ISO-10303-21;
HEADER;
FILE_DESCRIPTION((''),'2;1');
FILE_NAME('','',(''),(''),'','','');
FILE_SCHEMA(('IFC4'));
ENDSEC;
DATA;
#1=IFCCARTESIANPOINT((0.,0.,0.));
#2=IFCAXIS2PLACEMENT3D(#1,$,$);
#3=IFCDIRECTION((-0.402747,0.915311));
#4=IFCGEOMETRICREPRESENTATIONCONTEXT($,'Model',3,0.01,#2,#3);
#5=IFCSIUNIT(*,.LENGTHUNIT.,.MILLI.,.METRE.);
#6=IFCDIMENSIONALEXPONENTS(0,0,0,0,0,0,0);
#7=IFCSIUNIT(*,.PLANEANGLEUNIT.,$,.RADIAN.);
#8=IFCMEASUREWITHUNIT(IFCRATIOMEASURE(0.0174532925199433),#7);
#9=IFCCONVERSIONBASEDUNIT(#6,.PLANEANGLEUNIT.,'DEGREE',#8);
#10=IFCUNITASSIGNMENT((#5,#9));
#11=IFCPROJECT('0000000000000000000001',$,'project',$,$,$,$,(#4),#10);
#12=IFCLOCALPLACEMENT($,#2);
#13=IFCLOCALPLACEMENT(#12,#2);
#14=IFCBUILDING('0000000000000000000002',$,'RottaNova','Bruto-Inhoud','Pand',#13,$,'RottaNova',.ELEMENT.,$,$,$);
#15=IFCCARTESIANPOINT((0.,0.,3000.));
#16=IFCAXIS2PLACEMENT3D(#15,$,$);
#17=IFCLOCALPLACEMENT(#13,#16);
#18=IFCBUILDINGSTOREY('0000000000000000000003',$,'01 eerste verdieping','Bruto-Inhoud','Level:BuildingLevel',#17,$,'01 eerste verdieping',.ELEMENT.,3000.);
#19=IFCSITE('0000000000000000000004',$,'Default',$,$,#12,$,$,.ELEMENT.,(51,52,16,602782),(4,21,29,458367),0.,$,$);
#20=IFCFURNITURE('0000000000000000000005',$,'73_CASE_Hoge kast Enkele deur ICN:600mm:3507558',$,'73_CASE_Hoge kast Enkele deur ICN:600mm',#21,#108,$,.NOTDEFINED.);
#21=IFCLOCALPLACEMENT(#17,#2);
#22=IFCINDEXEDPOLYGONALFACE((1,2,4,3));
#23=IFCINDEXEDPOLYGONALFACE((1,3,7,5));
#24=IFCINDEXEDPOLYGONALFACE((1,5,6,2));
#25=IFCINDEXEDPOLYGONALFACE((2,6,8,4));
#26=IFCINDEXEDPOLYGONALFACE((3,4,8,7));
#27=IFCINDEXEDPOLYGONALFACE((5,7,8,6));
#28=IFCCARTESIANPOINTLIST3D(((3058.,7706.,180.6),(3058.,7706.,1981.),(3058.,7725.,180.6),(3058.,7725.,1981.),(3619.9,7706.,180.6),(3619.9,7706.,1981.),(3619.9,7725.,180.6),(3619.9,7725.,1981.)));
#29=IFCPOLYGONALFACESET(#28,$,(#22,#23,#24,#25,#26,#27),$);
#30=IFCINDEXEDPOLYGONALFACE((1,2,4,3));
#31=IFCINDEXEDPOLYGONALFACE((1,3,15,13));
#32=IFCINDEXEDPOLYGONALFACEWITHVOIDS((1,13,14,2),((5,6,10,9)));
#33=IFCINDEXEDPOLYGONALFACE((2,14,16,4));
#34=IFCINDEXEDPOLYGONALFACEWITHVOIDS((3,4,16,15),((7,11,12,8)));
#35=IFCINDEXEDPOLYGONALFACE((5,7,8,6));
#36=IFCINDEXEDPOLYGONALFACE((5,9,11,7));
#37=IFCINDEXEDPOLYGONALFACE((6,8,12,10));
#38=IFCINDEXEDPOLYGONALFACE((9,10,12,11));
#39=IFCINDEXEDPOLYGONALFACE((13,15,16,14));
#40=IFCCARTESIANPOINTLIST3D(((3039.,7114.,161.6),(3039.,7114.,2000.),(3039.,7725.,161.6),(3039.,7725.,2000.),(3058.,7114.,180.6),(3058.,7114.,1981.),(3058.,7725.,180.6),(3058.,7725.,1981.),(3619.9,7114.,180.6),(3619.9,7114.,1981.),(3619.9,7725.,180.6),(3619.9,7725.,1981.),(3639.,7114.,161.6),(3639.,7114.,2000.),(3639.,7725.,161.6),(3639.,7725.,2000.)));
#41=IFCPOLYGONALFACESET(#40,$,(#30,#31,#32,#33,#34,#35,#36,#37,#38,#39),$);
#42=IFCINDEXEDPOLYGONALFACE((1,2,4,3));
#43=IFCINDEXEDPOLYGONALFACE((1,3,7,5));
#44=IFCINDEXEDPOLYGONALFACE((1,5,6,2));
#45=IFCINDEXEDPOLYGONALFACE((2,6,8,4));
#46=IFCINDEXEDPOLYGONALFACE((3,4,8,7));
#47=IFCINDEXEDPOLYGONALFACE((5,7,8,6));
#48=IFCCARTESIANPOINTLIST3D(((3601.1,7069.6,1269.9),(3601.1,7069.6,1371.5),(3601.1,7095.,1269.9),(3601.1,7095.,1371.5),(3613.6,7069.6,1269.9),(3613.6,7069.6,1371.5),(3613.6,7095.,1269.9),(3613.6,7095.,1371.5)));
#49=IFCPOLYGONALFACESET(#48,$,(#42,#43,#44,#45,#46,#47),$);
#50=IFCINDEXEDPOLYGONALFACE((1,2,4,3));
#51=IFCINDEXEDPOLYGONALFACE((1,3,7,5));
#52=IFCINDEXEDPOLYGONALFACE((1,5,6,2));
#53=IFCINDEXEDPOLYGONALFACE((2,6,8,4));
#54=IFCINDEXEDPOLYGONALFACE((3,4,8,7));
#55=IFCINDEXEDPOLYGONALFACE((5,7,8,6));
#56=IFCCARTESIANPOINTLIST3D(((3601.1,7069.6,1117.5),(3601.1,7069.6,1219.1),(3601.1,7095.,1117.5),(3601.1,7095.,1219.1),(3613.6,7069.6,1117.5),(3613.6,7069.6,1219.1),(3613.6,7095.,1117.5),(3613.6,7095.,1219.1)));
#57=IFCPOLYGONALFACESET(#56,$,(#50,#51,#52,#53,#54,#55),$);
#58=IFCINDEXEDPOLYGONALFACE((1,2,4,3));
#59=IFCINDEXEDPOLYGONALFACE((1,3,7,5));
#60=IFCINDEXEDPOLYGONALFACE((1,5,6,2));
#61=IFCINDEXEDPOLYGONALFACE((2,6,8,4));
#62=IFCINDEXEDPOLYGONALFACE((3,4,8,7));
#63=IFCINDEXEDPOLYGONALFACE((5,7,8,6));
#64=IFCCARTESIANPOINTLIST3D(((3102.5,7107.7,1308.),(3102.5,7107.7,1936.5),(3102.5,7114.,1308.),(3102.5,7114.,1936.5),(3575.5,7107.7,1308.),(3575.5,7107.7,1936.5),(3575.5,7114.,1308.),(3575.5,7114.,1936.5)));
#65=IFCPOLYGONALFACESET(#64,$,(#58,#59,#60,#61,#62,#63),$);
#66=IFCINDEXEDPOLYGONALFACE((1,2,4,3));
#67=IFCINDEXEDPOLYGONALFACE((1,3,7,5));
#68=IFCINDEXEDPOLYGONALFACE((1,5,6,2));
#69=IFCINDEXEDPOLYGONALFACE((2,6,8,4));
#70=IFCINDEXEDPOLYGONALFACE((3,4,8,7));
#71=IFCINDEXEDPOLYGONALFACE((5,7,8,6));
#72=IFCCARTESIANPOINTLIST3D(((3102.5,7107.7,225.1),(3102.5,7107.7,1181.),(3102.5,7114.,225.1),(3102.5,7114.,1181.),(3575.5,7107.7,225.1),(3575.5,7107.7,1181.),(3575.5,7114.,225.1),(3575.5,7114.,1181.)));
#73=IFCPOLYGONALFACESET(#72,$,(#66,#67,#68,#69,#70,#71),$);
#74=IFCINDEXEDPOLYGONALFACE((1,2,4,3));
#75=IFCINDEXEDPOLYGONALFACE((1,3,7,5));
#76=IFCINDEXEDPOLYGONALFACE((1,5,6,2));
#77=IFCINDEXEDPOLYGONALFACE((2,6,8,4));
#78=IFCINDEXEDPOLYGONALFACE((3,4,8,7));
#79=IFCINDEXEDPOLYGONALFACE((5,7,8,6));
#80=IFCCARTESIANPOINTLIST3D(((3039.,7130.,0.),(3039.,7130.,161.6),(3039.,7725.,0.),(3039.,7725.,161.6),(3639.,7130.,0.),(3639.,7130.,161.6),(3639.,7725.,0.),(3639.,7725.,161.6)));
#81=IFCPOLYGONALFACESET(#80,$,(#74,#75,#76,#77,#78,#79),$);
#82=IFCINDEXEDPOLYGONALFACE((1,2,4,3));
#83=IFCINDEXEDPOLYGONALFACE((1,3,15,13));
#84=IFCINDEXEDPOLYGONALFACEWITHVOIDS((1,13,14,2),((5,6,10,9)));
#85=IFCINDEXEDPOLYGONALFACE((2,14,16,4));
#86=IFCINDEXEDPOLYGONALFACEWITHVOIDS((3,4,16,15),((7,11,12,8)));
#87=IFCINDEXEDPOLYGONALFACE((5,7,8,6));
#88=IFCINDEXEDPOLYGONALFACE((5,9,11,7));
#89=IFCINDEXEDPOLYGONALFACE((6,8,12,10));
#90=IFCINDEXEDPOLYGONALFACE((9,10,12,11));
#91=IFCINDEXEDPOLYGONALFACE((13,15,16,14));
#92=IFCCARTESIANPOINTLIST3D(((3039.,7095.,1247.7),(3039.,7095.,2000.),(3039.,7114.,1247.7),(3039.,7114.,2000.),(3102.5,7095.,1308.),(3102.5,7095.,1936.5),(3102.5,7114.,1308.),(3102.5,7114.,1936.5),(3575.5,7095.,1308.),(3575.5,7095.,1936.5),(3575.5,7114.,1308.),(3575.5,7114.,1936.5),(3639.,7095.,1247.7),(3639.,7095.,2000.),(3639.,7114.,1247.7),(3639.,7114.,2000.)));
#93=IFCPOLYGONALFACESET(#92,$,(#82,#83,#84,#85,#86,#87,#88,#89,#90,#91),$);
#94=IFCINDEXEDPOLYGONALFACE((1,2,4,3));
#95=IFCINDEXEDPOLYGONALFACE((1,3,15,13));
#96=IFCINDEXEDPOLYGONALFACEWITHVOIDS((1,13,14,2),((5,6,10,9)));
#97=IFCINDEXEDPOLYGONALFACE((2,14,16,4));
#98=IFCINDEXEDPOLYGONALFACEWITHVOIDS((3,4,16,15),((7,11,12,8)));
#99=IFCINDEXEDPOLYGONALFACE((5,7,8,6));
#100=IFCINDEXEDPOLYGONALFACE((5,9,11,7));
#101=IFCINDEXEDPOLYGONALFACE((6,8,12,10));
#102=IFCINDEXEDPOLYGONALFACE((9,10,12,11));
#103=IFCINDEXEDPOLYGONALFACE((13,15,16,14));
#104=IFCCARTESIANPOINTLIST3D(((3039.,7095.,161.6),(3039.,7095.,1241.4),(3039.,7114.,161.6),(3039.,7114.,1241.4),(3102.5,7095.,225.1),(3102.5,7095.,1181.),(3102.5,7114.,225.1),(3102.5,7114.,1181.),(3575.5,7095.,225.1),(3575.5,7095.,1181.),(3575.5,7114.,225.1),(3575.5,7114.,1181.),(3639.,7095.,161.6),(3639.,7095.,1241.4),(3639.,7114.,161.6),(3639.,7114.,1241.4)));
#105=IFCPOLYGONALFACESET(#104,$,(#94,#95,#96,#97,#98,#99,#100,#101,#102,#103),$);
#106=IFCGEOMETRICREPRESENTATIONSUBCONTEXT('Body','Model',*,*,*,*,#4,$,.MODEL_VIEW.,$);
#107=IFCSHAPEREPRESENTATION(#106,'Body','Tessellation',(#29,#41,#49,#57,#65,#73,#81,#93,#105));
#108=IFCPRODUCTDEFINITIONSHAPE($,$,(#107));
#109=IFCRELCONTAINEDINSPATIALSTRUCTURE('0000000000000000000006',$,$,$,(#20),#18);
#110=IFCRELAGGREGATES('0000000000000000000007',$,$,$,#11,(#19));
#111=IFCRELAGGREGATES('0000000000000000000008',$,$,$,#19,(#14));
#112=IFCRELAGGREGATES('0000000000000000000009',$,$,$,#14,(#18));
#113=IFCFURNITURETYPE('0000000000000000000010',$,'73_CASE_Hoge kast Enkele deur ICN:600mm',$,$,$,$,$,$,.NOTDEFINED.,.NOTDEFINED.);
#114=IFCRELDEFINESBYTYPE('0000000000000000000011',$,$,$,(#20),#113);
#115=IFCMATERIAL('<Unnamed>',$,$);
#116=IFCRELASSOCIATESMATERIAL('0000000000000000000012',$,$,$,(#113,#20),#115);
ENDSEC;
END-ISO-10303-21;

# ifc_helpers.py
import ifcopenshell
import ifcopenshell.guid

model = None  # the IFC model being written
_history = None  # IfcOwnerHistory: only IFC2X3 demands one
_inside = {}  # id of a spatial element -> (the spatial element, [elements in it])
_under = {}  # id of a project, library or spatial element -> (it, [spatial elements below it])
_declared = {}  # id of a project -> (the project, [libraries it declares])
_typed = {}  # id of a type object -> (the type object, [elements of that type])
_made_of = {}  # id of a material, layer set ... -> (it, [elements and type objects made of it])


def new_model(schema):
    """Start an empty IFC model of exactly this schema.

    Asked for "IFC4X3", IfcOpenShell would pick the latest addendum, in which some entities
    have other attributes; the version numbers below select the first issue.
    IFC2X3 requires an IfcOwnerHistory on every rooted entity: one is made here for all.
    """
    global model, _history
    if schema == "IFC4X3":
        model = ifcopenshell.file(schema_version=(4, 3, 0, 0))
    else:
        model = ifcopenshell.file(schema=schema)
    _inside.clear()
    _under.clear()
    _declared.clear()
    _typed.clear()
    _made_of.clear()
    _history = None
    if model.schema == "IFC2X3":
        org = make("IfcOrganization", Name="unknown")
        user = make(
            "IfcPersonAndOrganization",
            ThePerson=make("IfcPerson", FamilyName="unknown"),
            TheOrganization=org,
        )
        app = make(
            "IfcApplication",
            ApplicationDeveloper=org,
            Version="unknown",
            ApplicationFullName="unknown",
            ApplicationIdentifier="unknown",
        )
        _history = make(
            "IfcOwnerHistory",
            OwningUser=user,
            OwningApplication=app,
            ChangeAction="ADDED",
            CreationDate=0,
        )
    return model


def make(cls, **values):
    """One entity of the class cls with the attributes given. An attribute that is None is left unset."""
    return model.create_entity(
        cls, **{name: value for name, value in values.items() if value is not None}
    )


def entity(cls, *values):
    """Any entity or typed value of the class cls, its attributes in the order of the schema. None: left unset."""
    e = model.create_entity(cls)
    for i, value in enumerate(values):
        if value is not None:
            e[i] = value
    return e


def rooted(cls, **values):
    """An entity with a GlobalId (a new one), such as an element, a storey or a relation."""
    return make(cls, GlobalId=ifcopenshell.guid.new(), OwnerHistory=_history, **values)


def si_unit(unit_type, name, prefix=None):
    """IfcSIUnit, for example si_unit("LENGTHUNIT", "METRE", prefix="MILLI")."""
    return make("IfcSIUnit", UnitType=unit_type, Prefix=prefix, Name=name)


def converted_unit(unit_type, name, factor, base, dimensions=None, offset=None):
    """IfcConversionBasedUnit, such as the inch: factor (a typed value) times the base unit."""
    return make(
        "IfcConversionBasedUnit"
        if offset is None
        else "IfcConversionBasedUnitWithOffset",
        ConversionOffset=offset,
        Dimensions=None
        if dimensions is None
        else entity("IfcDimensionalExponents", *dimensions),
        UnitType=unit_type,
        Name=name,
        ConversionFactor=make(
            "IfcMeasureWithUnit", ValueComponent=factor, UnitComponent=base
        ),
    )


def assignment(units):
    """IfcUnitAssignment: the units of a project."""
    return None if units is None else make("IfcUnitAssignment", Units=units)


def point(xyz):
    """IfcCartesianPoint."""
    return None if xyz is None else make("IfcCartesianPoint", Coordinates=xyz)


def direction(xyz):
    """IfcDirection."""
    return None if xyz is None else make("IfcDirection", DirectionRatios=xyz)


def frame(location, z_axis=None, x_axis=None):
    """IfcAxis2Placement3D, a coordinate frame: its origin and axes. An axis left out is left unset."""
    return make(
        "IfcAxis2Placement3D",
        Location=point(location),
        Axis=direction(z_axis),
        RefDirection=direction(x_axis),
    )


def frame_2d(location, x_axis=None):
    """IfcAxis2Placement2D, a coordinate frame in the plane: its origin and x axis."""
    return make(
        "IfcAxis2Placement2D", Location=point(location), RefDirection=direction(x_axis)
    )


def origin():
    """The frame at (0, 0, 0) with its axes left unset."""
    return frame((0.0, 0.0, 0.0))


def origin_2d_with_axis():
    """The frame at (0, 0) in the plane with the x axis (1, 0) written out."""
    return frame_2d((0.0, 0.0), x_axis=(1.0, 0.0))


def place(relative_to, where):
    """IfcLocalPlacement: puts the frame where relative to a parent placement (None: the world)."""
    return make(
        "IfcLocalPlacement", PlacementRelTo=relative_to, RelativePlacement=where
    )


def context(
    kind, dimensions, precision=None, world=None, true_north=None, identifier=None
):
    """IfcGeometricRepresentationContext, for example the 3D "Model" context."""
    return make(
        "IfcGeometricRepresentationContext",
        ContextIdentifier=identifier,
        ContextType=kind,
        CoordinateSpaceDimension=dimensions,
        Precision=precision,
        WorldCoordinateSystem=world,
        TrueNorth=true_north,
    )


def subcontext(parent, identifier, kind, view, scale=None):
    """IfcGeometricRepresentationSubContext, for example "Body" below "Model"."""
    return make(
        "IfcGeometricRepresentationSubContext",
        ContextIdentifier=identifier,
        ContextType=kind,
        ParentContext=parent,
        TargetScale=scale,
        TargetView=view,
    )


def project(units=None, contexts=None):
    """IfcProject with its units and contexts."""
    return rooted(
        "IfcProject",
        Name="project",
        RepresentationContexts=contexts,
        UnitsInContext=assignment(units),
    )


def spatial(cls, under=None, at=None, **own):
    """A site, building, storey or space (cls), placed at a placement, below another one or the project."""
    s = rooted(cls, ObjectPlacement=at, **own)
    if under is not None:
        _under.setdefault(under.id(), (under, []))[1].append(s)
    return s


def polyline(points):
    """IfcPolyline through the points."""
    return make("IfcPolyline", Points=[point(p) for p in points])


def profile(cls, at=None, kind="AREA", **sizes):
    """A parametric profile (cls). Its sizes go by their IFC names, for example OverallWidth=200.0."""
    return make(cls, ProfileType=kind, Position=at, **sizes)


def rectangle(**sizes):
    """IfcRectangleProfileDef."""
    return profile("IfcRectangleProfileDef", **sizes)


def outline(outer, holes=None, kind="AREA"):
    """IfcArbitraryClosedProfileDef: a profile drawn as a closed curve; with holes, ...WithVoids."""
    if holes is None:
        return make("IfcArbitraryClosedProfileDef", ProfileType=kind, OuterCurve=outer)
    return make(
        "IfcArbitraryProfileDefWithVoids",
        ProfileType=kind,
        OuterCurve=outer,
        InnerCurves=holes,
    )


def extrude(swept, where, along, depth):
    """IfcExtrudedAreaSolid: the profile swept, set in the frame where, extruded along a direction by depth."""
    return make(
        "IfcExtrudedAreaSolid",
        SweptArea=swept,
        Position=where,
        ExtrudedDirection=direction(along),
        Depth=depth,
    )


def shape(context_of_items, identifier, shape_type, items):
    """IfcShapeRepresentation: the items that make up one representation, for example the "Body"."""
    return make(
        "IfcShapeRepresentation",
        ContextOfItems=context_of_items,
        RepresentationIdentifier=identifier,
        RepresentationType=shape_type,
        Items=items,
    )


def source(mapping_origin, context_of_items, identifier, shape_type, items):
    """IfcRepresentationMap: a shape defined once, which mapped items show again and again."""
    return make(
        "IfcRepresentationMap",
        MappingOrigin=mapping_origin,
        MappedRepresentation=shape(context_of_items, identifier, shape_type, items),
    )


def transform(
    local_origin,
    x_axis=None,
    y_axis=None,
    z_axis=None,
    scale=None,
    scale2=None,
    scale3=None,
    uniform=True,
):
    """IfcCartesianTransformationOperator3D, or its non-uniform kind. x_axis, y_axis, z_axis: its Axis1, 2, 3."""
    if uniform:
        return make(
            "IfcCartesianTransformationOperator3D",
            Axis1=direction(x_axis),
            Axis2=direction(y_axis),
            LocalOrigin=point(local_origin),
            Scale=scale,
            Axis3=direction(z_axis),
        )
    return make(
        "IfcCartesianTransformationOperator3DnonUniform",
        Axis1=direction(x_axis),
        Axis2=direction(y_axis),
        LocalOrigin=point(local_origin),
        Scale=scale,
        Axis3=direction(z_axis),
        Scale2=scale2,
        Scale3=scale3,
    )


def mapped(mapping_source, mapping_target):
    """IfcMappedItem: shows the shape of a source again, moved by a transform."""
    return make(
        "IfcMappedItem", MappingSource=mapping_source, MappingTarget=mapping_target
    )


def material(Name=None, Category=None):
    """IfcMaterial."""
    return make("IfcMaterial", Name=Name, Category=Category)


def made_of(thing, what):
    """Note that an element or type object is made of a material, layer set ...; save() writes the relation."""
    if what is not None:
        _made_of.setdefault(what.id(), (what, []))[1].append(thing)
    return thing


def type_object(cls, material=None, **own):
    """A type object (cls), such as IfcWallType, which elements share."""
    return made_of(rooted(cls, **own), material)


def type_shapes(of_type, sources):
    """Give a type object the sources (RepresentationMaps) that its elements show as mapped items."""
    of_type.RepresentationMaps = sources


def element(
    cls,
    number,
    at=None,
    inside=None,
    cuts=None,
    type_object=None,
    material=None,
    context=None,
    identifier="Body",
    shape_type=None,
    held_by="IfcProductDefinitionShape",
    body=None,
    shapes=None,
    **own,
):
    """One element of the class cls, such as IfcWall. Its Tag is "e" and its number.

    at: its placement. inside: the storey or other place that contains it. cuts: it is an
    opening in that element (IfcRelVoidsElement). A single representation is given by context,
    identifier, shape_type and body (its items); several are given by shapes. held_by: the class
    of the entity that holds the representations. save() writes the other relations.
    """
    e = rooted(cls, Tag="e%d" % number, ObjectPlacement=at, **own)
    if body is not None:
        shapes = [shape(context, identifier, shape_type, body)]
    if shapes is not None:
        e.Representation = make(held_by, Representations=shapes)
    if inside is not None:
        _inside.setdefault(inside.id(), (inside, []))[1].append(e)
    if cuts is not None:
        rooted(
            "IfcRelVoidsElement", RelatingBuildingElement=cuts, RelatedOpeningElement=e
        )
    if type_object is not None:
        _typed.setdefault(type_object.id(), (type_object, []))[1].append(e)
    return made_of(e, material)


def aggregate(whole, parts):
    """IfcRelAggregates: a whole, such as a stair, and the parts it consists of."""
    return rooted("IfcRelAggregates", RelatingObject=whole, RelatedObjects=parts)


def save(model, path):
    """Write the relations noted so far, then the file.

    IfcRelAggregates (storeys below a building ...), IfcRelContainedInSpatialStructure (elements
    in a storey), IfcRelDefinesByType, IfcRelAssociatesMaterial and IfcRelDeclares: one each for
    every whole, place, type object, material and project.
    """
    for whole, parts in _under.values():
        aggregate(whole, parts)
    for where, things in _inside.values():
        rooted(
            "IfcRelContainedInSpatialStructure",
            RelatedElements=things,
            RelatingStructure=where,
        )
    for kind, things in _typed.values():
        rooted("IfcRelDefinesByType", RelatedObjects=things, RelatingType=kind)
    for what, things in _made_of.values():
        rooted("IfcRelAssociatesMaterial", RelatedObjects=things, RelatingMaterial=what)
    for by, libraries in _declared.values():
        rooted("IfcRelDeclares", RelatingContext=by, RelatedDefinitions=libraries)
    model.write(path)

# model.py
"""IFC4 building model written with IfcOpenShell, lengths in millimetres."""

from ifc_helpers import new_model, entity, si_unit, converted_unit, direction, frame, frame_2d, origin, origin_2d_with_axis, place, context, subcontext, project, spatial, polyline, rectangle, outline, extrude, source, transform, mapped, material, type_object, type_shapes, element, save


model = new_model("IFC4")

# Units and contexts
model_context = context("Model", 3, precision=0.01, world=origin(), true_north=direction((-0.402747, 0.915311)))
body_context = subcontext(model_context, "Body", "Model", "MODEL_VIEW")
ifc_project = project(units=[si_unit("LENGTHUNIT", "METRE", prefix="MILLI"), converted_unit("PLANEANGLEUNIT", "DEGREE", entity("IfcRatioMeasure", 0.0174532925199433), si_unit("PLANEANGLEUNIT", "RADIAN"), dimensions=[0, 0, 0, 0, 0, 0, 0])], contexts=[model_context])

# Site, building, storey
site_placement = place(None, origin())
site = spatial("IfcSite", under=ifc_project, at=site_placement, Name="Default", CompositionType="ELEMENT", RefLatitude=(51, 52, 16, 602782), RefLongitude=(4, 21, 29, 458367), RefElevation=0.0)
building_placement = place(site_placement, origin())
building = spatial("IfcBuilding", under=site, at=building_placement, Name="RottaNova", Description="Bruto-Inhoud", ObjectType="Pand", LongName="RottaNova", CompositionType="ELEMENT")
storey_placement = place(building_placement, frame((0.0, 0.0, 3000.0)))
storey = spatial("IfcBuildingStorey", under=building, at=storey_placement, Name="01 eerste verdieping", Description="Bruto-Inhoud", ObjectType="Level:BuildingLevel", LongName="01 eerste verdieping", CompositionType="ELEMENT", Elevation=3000.0)

# Furniture
ifc_material_1 = material(Name="<Unnamed>")
furniture_type = type_object("IfcFurnitureType", Name="73_CASE_Hoge kast Enkele deur ICN:600mm", AssemblyPlace="NOTDEFINED", PredefinedType="NOTDEFINED", material=ifc_material_1)
shared_shape_1 = source(origin(), body_context, "Body", "SweptSolid", [
    extrude(rectangle(XDim=19.1, YDim=561.9, at=origin_2d_with_axis()), frame((18.7, -9.5, 180.6), z_axis=(0.0, 0.0, 1.0), x_axis=(0.0, 1.0, 0.0)), (0.0, 0.0, 1.0), 1800.3),
    extrude(outline(polyline([(-300.0, -919.2), (300.0, -919.2), (300.0, 919.2), (-300.0, 919.2), (-300.0, -919.2)]), holes=[polyline([(-280.9, 900.2), (281.0, 900.2), (281.0, -900.2), (-280.9, -900.2), (-280.9, 900.2)])]), frame((18.7, -611.0, 1080.8), z_axis=(0.0, 1.0, 0.0), x_axis=(-1.0, 0.0, 0.0)), (0.0, 0.0, 1.0), 610.9),
    extrude(rectangle(XDim=25.4, YDim=12.5, at=frame_2d((0.0, 0.0), x_axis=(1.0, 0.0))), frame((287.1, -642.7, 1269.9), z_axis=(0.0, 0.0, 1.0), x_axis=(0.0, 1.0, 0.0)), (0.0, 0.0, 1.0), 101.6),
    extrude(rectangle(XDim=25.4, YDim=12.5, at=frame_2d((0.0, 0.0), x_axis=(1.0, 0.0))), frame((287.1, -642.7, 1117.5), z_axis=(0.0, 0.0, 1.0), x_axis=(0.0, 1.0, 0.0)), (0.0, 0.0, 1.0), 101.6),
    extrude(rectangle(XDim=6.4, YDim=473.0, at=frame_2d((0.0, 0.0), x_axis=(1.0, 0.0))), frame((18.7, -614.1, 1308.0), z_axis=(0.0, 0.0, 1.0), x_axis=(0.0, 1.0, 0.0)), (0.0, 0.0, 1.0), 628.5),
    extrude(rectangle(XDim=6.4, YDim=473.0, at=origin_2d_with_axis()), frame((18.7, -614.1, 225.1), z_axis=(0.0, 0.0, 1.0), x_axis=(0.0, 1.0, 0.0)), (0.0, 0.0, 1.0), 956.0),
    extrude(rectangle(XDim=600.0, YDim=595.0, at=frame_2d((0.0, 0.0), x_axis=(1.0, 0.0))), frame((18.7, -297.5, 0.0), z_axis=(0.0, 0.0, 1.0), x_axis=(-1.0, 0.0, 0.0)), (0.0, 0.0, 1.0), 161.6),
    extrude(outline(polyline([(-376.1, -300.0), (376.1, -300.0), (376.1, 300.0), (-376.1, 300.0), (-376.1, -300.0)]), holes=[polyline([(-312.6, -236.5), (-312.6, 236.5), (315.8, 236.5), (315.8, -236.5), (-312.6, -236.5)])]), frame((18.7, -630.0, 1623.9), z_axis=(0.0, 1.0, 0.0), x_axis=(0.0, 0.0, -1.0)), (0.0, 0.0, 1.0), 19.1),
    extrude(outline(polyline([(-300.0, -539.9), (300.0, -539.9), (300.0, 539.9), (-300.0, 539.9), (-300.0, -539.9)]), holes=[polyline([(-236.5, 479.6), (236.5, 479.6), (236.5, -476.4), (-236.5, -476.4), (-236.5, 479.6)])]), frame((18.7, -630.0, 701.5), z_axis=(0.0, 1.0, 0.0), x_axis=(-1.0, 0.0, 0.0)), (0.0, 0.0, 1.0), 19.1),
])
type_shapes(furniture_type, [shared_shape_1])
for number, where, name in (
    (1, (3320.3, 7725.0, 0.0), "73_CASE_Hoge kast Enkele deur ICN:600mm:3507558"),
):
    element("IfcFurniture", number, at=place(storey_placement, frame(where)), inside=storey, type_object=furniture_type, material=ifc_material_1, Name=name, ObjectType="73_CASE_Hoge kast Enkele deur ICN:600mm", PredefinedType="NOTDEFINED", context=body_context, shape_type="MappedRepresentation", body=[
        mapped(shared_shape_1, transform((0.0, 0.0, 0.0), scale=1.0)),
    ])

save(model, "model.ifc")
